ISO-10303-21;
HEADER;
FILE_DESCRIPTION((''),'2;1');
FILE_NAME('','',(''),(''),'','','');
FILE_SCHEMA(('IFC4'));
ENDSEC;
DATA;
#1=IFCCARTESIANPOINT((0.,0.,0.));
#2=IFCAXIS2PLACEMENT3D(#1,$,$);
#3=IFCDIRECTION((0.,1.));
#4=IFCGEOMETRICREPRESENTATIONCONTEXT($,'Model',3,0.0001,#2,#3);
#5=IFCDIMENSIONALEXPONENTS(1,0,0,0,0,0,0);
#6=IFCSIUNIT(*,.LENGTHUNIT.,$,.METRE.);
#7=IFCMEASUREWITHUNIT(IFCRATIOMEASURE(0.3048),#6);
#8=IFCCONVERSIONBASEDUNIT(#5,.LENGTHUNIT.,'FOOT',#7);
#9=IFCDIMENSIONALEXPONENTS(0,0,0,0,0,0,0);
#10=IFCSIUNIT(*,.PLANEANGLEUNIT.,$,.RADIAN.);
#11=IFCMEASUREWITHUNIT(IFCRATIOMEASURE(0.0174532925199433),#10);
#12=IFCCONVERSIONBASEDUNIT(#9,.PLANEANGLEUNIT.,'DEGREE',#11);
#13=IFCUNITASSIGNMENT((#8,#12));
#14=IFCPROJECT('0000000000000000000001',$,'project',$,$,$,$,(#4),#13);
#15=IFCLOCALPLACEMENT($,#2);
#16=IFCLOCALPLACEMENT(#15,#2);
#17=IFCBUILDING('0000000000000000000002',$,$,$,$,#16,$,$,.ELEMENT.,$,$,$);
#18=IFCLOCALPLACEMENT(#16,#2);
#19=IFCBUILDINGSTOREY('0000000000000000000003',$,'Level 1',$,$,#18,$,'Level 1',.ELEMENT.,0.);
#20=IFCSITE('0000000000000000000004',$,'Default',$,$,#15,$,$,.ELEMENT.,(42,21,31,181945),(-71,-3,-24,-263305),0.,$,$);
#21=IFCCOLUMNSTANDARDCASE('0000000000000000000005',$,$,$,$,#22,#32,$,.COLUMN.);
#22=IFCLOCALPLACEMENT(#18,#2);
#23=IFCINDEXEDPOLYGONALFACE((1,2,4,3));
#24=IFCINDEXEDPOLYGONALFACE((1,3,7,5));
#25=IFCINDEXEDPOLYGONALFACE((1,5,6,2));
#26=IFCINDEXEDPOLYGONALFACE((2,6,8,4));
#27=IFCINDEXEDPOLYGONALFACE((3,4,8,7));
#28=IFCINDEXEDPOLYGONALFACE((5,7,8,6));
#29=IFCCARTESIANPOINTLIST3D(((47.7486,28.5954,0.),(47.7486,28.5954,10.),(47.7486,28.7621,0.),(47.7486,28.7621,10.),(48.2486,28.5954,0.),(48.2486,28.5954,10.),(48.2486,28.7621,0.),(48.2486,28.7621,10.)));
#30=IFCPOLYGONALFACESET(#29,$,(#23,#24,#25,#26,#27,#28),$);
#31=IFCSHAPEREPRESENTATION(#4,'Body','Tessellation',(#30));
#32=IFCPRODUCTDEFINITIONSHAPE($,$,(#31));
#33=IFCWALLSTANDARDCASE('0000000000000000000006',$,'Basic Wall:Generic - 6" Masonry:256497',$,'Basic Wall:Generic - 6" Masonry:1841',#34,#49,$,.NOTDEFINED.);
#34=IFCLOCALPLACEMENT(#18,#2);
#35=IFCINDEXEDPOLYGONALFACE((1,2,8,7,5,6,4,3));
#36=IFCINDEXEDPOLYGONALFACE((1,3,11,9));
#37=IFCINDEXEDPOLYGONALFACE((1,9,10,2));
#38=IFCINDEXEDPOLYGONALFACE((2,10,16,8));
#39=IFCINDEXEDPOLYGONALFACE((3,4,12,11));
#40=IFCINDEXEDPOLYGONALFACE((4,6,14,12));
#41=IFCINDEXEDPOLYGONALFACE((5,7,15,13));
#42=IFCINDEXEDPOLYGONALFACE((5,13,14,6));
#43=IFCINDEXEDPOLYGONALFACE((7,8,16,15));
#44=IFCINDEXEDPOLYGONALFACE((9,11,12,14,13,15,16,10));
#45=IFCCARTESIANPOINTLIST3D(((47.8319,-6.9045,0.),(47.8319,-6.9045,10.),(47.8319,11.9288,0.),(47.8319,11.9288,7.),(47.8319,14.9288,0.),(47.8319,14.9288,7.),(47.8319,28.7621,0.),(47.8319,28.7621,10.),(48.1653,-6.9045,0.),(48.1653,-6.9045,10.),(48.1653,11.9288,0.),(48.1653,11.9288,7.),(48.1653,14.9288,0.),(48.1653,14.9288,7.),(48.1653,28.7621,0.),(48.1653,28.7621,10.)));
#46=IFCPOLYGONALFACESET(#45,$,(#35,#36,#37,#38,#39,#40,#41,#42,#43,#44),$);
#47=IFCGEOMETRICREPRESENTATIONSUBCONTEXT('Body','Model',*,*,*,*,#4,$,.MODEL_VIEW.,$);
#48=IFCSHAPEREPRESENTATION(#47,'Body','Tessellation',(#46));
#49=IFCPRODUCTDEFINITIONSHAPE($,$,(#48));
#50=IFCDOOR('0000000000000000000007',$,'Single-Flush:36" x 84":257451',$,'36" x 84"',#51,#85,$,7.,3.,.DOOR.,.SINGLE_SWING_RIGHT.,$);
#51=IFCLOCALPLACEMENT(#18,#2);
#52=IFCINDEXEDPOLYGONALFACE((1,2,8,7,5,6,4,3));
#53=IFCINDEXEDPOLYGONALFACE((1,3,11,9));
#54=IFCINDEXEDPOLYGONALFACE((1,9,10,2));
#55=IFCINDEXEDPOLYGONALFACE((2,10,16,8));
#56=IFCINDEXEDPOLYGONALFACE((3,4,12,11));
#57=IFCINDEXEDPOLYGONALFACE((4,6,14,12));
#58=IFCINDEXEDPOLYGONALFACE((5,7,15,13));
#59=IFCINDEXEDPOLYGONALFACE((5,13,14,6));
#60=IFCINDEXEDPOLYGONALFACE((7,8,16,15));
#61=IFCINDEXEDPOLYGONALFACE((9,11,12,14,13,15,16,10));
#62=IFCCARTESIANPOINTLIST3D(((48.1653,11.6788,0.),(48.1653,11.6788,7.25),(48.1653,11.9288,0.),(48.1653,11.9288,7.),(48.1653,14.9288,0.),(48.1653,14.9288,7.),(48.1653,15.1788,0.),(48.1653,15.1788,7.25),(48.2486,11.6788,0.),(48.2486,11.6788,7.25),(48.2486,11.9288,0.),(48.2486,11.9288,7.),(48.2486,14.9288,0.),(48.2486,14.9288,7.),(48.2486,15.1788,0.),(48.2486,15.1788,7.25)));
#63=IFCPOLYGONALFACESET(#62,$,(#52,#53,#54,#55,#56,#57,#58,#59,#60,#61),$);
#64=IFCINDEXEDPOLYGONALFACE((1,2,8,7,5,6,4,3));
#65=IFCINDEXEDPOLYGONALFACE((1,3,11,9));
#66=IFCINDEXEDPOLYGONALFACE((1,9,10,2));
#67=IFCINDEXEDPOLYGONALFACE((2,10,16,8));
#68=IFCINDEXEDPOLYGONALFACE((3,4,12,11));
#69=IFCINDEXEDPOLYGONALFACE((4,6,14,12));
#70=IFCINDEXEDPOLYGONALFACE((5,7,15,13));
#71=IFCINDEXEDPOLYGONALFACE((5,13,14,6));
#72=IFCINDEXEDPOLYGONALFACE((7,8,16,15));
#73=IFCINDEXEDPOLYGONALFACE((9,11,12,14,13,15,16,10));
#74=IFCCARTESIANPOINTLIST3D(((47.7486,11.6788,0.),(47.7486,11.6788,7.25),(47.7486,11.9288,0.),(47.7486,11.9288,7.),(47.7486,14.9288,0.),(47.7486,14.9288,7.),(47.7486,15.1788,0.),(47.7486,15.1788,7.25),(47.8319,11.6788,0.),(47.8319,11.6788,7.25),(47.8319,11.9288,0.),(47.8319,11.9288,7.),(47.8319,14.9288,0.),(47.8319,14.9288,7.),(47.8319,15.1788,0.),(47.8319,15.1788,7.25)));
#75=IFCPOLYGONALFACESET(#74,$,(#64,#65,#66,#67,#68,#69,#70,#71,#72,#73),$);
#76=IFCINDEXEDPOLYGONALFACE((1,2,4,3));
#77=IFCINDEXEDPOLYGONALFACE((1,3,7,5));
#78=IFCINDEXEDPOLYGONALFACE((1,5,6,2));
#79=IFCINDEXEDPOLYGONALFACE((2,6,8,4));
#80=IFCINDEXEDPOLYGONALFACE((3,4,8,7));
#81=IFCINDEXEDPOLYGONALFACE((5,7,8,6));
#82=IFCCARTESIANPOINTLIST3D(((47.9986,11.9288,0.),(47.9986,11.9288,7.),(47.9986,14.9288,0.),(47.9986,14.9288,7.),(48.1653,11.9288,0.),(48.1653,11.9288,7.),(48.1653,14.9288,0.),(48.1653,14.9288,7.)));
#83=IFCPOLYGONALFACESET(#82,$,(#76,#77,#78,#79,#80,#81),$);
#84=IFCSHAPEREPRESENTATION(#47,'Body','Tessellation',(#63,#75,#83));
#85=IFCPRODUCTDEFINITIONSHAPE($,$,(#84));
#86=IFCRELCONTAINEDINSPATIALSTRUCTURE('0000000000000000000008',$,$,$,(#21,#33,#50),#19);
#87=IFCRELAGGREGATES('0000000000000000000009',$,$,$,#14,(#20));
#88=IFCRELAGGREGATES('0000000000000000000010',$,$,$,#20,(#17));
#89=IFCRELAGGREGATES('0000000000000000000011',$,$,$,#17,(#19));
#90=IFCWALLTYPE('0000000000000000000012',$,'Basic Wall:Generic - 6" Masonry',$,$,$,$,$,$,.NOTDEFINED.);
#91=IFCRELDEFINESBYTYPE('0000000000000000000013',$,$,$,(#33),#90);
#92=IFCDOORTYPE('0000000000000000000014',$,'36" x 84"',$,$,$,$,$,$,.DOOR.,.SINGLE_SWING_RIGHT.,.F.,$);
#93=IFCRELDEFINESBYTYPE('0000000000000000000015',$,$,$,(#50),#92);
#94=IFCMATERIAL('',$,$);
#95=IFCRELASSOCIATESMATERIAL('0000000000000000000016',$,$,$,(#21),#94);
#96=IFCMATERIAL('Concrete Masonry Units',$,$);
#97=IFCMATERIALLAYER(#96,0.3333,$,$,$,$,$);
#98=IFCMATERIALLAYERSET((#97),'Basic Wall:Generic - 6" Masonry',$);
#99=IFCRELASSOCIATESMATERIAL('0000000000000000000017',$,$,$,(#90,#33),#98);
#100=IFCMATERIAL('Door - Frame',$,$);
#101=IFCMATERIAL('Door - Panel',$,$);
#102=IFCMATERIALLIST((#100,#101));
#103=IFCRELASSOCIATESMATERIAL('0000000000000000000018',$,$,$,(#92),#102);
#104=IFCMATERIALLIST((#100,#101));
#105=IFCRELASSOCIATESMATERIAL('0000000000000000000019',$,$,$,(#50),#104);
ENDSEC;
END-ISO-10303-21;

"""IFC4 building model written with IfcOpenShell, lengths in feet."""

from ifc_helpers import new_model, entity, si_unit, converted_unit, direction, frame, frame_2d, origin, place, context, subcontext, project, spatial, polyline, rectangle, outline, extrude, source, transform, mapped, material, material_list, layer, layer_set, layer_usage, type_object, type_shapes, element, fill, save


model = new_model("IFC4")

# Units and contexts
model_context = context("Model", 3, precision=0.0001, world=origin(), true_north=direction((0.0, 1.0)))
body_context = subcontext(model_context, "Body", "Model", "MODEL_VIEW")
ifc_project = project(units=[converted_unit("LENGTHUNIT", "FOOT", entity("IfcRatioMeasure", 0.3048), si_unit("LENGTHUNIT", "METRE"), dimensions=[1, 0, 0, 0, 0, 0, 0]), converted_unit("PLANEANGLEUNIT", "DEGREE", entity("IfcRatioMeasure", 0.0174532925199433), si_unit("PLANEANGLEUNIT", "RADIAN"), dimensions=[0, 0, 0, 0, 0, 0, 0])], contexts=[model_context])

# Site, building, storey
site_placement = place(None, origin())
site = spatial("IfcSite", under=ifc_project, at=site_placement, Name="Default", CompositionType="ELEMENT", RefLatitude=(42, 21, 31, 181945), RefLongitude=(-71, -3, -24, -263305), RefElevation=0.0)
building_placement = place(site_placement, origin())
building = spatial("IfcBuilding", under=site, at=building_placement, CompositionType="ELEMENT")
storey_placement = place(building_placement, origin())
storey = spatial("IfcBuildingStorey", under=building, at=storey_placement, Name="Level 1", LongName="Level 1", CompositionType="ELEMENT", Elevation=0.0)

# Column
ifc_material_1 = material(Name="")
wall_placement = place(storey_placement, frame((47.9986, 28.7621, 0.0), z_axis=(0.0, 0.0, 1.0), x_axis=(0.0, -1.0, 0.0)))
for number, where, z_axis, x_axis in (
    (1, (0.0833, 0.0, 0.0), (0.0, 0.0, 1.0), (1.0, 0.0, 0.0)),
):
    element("IfcColumnStandardCase", number, at=place(wall_placement, frame(where, z_axis=z_axis, x_axis=x_axis)), inside=storey, material=ifc_material_1, PredefinedType="COLUMN", context=model_context, shape_type="SweptSolid", body=[
        extrude(rectangle(XDim=0.1667, YDim=0.5), origin(), (0.0, 0.0, 1.0), 10.0),
    ])

# Wall, opening, door
ifc_material_2 = material(Name="Concrete Masonry Units")
ifc_layer = layer(ifc_material_2, 0.3333)
ifc_layer_set = layer_set([ifc_layer], Name="Basic Wall:Generic - 6\" Masonry")
ifc_layer_usage = layer_usage(ifc_layer_set, "AXIS2", "NEGATIVE", 0.1667)
wall_type = type_object("IfcWallType", Name="Basic Wall:Generic - 6\" Masonry", PredefinedType="NOTDEFINED", material=ifc_layer_set)
wall = element("IfcWallStandardCase", 2, at=wall_placement, inside=storey, type_object=wall_type, material=ifc_layer_usage, Name="Basic Wall:Generic - 6\" Masonry:256497", ObjectType="Basic Wall:Generic - 6\" Masonry:1841", PredefinedType="NOTDEFINED", context=body_context, shape_type="SweptSolid", body=[
    extrude(rectangle(XDim=35.6667, YDim=0.3333, at=frame_2d((17.8333, 0.0), x_axis=(-1.0, 0.0))), origin(), (0.0, 0.0, 1.0), 10.0),
])
opening_placement = place(wall_placement, frame((13.8333, -0.1667, 0.0)))
opening = element("IfcOpeningElement", 3, at=opening_placement, cuts=wall, ObjectType="Opening", PredefinedType="OPENING", context=body_context, shape_type="SweptSolid", body=[
    extrude(rectangle(XDim=3.0, YDim=7.0, at=frame_2d((3.5, 1.5), x_axis=(0.0, 1.0))), frame((0.0, 0.0, 0.0), z_axis=(0.0, 1.0, 0.0), x_axis=(0.0, 0.0, 1.0)), (0.0, 0.0, 1.0), 0.3333),
])
ifc_material_3 = material(Name="Door - Frame")
ifc_material_4 = material(Name="Door - Panel")
ifc_material_list_1 = material_list([ifc_material_3, ifc_material_4])
ifc_material_list_2 = material_list([ifc_material_3, ifc_material_4])
door_type = type_object("IfcDoorType", Name="36\" x 84\"", OperationType="SINGLE_SWING_RIGHT", ParameterTakesPrecedence=False, PredefinedType="DOOR", material=ifc_material_list_2)
shared_shape = source(origin(), body_context, "Body", "SweptSolid", [
    extrude(outline(polyline([(-1.75, -3.6875), (1.75, -3.6875), (1.75, 3.5625), (1.5, 3.5625), (1.5, -3.4375), (-1.5, -3.4375), (-1.5, 3.5625), (-1.75, 3.5625), (-1.75, -3.6875)])), frame((1.5, 0.3333, 3.5625), z_axis=(0.0, 1.0, 0.0), x_axis=(1.0, 0.0, 0.0)), (0.0, 0.0, 1.0), 0.0833),
    extrude(outline(polyline([(-3.6875, -1.75), (3.5625, -1.75), (3.5625, -1.5), (-3.4375, -1.5), (-3.4375, 1.5), (3.5625, 1.5), (3.5625, 1.75), (-3.6875, 1.75), (-3.6875, -1.75)])), frame((1.5, -0.0833, 3.5625), z_axis=(0.0, 1.0, 0.0), x_axis=(0.0, 0.0, -1.0)), (0.0, 0.0, 1.0), 0.0833),
    extrude(rectangle(XDim=0.1667, YDim=3.0, at=frame_2d((0.0, 0.0), x_axis=(1.0, 0.0))), frame((1.5, 0.25, 0.0), z_axis=(0.0, 0.0, 1.0), x_axis=(0.0, 1.0, 0.0)), (0.0, 0.0, 1.0), 7.0),
])
type_shapes(door_type, [shared_shape])
door_placement = place(opening_placement, origin())
door = element("IfcDoor", 4, at=door_placement, inside=storey, type_object=door_type, material=ifc_material_list_1, Name="Single-Flush:36\" x 84\":257451", ObjectType="36\" x 84\"", OperationType="SINGLE_SWING_RIGHT", OverallHeight=7.0, OverallWidth=3.0, PredefinedType="DOOR", context=body_context, shape_type="MappedRepresentation", body=[
    mapped(shared_shape, transform((0.0, 0.0, 0.0), scale=1.0)),
])
fill(opening, door)

save(model, "model.ifc")
